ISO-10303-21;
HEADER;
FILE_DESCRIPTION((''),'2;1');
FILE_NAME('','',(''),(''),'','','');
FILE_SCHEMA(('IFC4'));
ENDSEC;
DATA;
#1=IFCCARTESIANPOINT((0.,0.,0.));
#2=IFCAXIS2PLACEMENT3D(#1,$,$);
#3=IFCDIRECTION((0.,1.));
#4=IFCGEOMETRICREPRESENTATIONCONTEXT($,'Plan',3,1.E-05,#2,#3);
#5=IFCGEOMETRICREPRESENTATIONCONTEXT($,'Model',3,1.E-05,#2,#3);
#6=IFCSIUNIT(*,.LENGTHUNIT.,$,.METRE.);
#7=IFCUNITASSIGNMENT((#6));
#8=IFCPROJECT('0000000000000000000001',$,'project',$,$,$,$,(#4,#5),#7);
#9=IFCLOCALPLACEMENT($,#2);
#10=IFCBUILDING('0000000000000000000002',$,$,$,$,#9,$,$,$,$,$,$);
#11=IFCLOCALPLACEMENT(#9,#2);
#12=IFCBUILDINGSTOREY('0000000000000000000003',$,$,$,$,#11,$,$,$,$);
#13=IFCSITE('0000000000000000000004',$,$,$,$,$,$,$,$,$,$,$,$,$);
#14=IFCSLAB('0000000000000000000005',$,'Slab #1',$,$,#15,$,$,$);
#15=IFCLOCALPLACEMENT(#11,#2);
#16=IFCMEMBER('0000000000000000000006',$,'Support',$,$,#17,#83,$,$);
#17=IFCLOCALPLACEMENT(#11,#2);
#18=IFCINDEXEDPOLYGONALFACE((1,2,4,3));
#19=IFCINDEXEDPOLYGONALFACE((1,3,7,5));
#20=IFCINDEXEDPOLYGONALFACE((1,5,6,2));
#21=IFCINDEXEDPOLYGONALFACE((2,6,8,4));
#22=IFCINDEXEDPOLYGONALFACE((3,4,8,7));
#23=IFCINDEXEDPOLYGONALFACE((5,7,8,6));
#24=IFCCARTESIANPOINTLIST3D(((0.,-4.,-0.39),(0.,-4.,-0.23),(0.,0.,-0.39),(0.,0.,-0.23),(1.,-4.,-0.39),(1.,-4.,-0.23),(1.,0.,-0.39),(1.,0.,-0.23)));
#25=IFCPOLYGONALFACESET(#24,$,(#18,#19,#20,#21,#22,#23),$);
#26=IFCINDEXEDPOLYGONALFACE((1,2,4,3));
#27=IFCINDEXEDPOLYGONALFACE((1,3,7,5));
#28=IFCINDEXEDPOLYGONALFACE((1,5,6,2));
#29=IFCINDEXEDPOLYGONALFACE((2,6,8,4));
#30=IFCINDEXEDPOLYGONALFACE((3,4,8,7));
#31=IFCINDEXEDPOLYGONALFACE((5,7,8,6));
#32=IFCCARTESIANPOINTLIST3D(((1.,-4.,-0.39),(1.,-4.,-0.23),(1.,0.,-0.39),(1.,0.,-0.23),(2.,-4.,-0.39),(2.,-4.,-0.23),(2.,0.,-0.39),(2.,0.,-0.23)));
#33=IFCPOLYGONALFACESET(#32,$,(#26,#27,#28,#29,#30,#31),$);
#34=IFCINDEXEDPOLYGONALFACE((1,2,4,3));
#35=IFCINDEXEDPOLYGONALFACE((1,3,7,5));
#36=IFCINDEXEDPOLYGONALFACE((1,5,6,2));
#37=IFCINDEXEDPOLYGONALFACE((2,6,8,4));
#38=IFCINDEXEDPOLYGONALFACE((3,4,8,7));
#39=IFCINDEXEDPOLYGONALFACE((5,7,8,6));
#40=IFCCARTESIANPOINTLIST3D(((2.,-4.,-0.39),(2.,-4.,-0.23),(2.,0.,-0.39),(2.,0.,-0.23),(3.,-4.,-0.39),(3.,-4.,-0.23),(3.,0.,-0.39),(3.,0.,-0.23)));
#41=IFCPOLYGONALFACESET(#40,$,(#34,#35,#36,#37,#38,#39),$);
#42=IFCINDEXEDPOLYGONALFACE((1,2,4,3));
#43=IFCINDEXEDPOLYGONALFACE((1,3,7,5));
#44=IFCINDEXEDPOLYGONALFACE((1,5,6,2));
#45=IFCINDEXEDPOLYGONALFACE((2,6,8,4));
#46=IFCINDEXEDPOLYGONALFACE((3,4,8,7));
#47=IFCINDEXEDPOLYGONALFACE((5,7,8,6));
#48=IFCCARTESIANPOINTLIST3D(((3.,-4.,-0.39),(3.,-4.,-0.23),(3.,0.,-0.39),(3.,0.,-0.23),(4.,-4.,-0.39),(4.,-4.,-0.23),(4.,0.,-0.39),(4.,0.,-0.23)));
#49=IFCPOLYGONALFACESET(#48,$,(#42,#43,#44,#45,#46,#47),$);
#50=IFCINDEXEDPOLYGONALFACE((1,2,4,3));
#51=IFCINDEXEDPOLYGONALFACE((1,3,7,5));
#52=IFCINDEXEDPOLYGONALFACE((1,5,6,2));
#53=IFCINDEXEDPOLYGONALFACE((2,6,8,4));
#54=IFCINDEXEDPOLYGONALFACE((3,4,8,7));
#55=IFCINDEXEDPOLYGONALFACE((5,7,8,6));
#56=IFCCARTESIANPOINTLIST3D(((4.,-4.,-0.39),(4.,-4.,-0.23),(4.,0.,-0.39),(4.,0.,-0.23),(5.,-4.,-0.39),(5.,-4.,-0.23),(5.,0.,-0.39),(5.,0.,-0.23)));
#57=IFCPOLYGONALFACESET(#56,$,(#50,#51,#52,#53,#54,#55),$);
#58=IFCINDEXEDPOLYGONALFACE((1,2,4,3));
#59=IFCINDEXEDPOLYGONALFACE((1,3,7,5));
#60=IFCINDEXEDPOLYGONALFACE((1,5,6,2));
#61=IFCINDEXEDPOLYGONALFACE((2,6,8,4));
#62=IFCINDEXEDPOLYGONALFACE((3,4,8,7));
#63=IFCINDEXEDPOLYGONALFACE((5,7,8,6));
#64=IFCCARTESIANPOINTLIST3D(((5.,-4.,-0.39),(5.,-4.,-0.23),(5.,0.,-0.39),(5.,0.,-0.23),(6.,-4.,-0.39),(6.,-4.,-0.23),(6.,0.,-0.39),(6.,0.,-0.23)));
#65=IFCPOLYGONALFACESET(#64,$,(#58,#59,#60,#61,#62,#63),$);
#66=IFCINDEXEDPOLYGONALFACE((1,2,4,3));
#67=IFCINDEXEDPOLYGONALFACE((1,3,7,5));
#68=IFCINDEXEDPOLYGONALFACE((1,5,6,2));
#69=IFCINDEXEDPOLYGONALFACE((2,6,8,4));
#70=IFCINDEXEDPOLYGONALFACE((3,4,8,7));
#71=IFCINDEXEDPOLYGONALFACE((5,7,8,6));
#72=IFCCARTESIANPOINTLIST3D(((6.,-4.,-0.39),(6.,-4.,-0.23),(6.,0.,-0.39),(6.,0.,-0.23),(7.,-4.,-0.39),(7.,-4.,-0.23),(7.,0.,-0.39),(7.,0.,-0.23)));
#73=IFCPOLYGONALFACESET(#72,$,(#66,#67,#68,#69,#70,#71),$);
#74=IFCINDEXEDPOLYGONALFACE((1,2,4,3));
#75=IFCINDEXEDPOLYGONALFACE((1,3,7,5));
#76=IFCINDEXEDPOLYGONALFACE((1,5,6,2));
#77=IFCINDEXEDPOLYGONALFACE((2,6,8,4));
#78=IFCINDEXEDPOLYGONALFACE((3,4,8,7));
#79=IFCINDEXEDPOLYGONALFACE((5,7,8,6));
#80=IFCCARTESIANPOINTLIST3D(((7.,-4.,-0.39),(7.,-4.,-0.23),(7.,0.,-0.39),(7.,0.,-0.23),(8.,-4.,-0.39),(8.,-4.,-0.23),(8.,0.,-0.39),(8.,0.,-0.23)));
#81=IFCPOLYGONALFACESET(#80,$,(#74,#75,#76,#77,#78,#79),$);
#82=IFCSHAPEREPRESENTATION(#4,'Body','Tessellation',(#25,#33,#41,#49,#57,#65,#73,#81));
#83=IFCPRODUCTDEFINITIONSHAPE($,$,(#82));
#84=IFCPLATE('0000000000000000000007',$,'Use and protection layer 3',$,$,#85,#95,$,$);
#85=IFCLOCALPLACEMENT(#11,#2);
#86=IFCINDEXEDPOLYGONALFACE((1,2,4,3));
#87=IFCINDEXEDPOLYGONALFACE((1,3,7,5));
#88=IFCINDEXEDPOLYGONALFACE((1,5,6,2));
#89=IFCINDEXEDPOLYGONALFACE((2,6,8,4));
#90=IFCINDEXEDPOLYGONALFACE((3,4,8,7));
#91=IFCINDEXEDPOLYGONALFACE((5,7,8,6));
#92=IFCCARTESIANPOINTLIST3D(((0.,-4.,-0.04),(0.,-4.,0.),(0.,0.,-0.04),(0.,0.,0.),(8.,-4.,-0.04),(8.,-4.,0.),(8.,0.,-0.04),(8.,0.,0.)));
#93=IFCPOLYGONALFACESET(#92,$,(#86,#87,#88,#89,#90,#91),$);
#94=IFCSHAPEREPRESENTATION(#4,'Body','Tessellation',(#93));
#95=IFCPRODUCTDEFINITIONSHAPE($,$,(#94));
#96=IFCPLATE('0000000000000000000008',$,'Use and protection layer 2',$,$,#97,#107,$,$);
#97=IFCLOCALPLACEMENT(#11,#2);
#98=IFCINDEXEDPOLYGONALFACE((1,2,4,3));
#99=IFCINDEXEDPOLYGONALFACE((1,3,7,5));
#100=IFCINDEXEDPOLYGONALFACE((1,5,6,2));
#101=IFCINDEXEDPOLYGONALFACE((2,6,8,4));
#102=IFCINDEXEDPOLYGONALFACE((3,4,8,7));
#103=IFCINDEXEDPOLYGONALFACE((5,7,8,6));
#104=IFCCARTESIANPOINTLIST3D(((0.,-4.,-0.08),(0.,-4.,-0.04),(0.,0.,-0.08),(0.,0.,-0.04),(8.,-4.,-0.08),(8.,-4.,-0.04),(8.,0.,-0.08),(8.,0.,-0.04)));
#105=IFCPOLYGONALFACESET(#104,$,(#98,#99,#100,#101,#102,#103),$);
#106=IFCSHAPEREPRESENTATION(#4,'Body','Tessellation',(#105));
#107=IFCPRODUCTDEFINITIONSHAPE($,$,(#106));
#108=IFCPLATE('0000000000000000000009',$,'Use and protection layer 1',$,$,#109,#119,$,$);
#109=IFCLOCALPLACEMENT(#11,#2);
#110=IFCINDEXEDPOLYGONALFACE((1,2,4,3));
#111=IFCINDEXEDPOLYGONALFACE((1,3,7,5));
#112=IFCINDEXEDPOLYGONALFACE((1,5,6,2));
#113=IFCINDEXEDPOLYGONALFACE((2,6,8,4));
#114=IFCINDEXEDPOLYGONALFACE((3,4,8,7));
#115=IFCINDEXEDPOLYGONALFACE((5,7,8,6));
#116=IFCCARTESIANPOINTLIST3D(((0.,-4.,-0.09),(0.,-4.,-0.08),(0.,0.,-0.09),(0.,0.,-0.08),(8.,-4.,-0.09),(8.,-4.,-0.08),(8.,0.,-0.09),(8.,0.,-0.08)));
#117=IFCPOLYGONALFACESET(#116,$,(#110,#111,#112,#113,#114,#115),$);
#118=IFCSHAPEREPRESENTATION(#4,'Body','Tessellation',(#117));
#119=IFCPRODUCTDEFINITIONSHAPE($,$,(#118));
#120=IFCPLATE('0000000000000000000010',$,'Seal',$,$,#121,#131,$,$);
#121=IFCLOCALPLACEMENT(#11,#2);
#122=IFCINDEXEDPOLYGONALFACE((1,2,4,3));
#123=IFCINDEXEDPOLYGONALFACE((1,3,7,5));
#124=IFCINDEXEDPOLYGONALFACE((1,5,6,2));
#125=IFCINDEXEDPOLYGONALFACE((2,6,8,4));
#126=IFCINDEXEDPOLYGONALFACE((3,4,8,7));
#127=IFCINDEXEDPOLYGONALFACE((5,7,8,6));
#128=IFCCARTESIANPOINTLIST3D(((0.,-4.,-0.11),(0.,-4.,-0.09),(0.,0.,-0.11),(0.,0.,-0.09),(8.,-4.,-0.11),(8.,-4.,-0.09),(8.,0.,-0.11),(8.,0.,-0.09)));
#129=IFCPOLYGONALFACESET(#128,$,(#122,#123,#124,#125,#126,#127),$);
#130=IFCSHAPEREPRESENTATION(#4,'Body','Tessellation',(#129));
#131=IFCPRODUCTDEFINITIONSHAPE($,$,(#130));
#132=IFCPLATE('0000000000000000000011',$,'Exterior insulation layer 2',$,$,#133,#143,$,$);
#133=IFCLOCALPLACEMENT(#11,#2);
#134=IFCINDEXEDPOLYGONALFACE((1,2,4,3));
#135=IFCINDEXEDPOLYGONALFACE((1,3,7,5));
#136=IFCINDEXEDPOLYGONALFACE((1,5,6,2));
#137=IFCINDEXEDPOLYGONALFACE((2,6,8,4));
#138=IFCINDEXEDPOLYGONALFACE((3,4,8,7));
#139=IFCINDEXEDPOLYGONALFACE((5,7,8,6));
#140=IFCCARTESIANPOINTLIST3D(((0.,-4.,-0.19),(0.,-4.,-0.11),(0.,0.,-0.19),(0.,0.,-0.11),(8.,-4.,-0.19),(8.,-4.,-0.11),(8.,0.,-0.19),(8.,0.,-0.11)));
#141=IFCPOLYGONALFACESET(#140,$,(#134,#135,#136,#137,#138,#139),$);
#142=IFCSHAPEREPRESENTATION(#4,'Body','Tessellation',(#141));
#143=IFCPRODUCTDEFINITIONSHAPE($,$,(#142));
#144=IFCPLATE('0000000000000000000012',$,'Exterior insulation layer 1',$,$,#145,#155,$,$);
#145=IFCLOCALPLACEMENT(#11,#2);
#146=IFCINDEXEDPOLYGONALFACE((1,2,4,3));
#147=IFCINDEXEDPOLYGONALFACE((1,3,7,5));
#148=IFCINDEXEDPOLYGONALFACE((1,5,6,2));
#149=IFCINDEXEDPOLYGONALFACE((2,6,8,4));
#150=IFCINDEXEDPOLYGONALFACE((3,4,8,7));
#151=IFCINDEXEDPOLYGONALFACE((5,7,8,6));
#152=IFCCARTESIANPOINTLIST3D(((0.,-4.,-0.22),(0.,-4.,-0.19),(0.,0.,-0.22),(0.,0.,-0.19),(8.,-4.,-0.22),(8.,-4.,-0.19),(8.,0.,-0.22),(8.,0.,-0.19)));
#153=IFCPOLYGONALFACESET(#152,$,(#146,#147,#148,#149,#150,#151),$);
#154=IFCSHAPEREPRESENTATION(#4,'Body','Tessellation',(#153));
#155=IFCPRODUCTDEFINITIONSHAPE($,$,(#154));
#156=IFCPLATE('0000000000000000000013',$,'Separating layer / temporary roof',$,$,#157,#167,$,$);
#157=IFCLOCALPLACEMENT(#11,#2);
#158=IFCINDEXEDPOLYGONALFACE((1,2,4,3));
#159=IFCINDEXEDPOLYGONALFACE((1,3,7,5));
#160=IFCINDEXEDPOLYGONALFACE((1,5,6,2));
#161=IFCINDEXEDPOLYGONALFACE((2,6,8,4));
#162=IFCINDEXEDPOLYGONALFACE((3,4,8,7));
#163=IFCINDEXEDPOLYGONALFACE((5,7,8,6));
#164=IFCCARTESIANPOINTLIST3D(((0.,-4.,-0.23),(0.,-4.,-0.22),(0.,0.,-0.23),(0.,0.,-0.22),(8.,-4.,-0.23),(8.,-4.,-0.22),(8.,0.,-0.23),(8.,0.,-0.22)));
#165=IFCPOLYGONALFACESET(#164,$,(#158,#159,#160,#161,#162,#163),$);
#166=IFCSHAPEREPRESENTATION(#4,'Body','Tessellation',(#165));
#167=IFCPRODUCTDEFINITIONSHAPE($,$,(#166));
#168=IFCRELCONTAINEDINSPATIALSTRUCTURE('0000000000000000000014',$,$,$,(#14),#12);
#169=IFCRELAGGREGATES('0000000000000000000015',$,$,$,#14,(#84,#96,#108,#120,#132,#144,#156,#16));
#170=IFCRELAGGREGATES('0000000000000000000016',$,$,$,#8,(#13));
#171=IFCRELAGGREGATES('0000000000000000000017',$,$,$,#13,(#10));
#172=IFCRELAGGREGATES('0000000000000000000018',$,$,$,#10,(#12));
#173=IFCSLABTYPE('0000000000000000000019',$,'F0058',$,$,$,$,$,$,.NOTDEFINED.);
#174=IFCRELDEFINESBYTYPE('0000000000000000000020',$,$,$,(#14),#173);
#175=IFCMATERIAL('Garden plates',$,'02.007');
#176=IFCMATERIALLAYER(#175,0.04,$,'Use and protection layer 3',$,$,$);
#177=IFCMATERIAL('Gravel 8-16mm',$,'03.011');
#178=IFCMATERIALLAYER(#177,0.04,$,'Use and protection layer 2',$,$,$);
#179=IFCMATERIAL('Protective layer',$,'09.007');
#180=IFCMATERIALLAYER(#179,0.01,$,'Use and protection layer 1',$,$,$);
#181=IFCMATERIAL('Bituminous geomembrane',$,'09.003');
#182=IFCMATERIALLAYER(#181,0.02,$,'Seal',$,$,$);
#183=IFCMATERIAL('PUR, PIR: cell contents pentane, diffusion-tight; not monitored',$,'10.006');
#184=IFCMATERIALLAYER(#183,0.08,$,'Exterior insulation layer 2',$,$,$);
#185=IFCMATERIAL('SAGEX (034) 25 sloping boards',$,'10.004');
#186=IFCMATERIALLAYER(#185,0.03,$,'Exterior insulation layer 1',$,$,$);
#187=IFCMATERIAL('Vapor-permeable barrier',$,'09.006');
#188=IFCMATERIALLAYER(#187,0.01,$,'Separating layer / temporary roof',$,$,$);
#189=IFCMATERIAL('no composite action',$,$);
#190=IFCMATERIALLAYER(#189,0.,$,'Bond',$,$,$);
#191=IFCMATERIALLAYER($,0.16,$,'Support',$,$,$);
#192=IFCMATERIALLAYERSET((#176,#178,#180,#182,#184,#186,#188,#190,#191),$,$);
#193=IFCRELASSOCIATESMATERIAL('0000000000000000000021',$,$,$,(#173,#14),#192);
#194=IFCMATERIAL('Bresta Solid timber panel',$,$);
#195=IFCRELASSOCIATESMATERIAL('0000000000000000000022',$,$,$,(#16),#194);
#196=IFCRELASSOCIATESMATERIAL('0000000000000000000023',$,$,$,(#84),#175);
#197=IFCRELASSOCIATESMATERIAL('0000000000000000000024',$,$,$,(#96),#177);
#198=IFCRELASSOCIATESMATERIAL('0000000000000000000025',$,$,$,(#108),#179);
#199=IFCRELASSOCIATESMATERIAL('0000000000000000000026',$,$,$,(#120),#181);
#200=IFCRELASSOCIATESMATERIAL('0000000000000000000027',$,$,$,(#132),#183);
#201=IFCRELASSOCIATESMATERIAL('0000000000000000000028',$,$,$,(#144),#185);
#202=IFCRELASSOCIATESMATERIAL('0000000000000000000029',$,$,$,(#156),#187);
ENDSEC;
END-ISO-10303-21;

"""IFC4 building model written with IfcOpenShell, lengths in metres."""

from ifc_helpers import new_model, si_unit, direction, frame, frame_2d, origin, origin_with_axes, place, context, project, spatial, rectangle, extrude, material, layer, layer_set, type_object, element, aggregate, save


model = new_model("IFC4")

# Units and contexts
plan_context = context("Plan", 3, precision=1e-05, world=origin(), true_north=direction((0.0, 1.0)))
model_context = context("Model", 3, precision=1e-05, world=origin(), true_north=direction((0.0, 1.0)))
ifc_project = project(units=[si_unit("LENGTHUNIT", "METRE")], contexts=[plan_context, model_context])

# Site, building, storey
site = spatial("IfcSite", under=ifc_project)
building_placement = place(None, origin())
building = spatial("IfcBuilding", under=site, at=building_placement)
storey_placement = place(building_placement, origin())
storey = spatial("IfcBuildingStorey", under=building, at=storey_placement)

# Slab, member, plates
ifc_material_1 = material(Name="Garden plates", Category="02.007")
ifc_layer_1 = layer(ifc_material_1, 0.04, Name="Use and protection layer 3")
ifc_material_2 = material(Name="Gravel 8-16mm", Category="03.011")
ifc_layer_2 = layer(ifc_material_2, 0.04, Name="Use and protection layer 2")
ifc_material_3 = material(Name="Protective layer", Category="09.007")
ifc_layer_3 = layer(ifc_material_3, 0.01, Name="Use and protection layer 1")
ifc_material_4 = material(Name="Bituminous geomembrane", Category="09.003")
ifc_layer_4 = layer(ifc_material_4, 0.02, Name="Seal")
ifc_material_5 = material(Name="PUR, PIR: cell contents pentane, diffusion-tight; not monitored", Category="10.006")
ifc_layer_5 = layer(ifc_material_5, 0.08, Name="Exterior insulation layer 2")
ifc_material_6 = material(Name="SAGEX (034) 25 sloping boards", Category="10.004")
ifc_layer_6 = layer(ifc_material_6, 0.03, Name="Exterior insulation layer 1")
ifc_material_7 = material(Name="Vapor-permeable barrier", Category="09.006")
ifc_layer_7 = layer(ifc_material_7, 0.01, Name="Separating layer / temporary roof")
ifc_material_8 = material(Name="no composite action")
ifc_layer_8 = layer(ifc_material_8, 0.0, Name="Bond")
ifc_layer_9 = layer(None, 0.16, Name="Support")
ifc_layer_set = layer_set([ifc_layer_1, ifc_layer_2, ifc_layer_3, ifc_layer_4, ifc_layer_5, ifc_layer_6, ifc_layer_7, ifc_layer_8, ifc_layer_9])
slab_type = type_object("IfcSlabType", Name="F0058", PredefinedType="NOTDEFINED", material=ifc_layer_set)
slab_placement = place(None, frame((0.0, 0.0, 0.0), z_axis=(0.0, 0.0, -1.0), x_axis=(1.0, 0.0, 0.0)))
slab = element("IfcSlab", 1, at=slab_placement, inside=storey, type_object=slab_type, material=ifc_layer_set, Name="Slab #1")
ifc_material_9 = material(Name="Bresta Solid timber panel")
member_placement = place(slab_placement, origin())
member = element("IfcMember", 2, at=member_placement, material=ifc_material_9, Name="Support", context=plan_context, shape_type="SweptSolid", body=[
    extrude(rectangle(XDim=1.0, YDim=0.16, at=frame_2d((0.5, 0.08), x_axis=(1.0, 0.0))), frame((0.0, 4.0, 0.23), z_axis=(0.0, -1.0, 0.0), x_axis=(1.0, 0.0, 0.0)), (0.0, 0.0, 1.0), 4.0),
    extrude(rectangle(XDim=1.0, YDim=0.16, at=frame_2d((0.5, 0.08), x_axis=(1.0, 0.0))), frame((1.0, 4.0, 0.23), z_axis=(0.0, -1.0, 0.0), x_axis=(1.0, 0.0, 0.0)), (0.0, 0.0, 1.0), 4.0),
    extrude(rectangle(XDim=1.0, YDim=0.16, at=frame_2d((0.5, 0.08), x_axis=(1.0, 0.0))), frame((2.0, 4.0, 0.23), z_axis=(0.0, -1.0, 0.0), x_axis=(1.0, 0.0, 0.0)), (0.0, 0.0, 1.0), 4.0),
    extrude(rectangle(XDim=1.0, YDim=0.16, at=frame_2d((0.5, 0.08), x_axis=(1.0, 0.0))), frame((3.0, 4.0, 0.23), z_axis=(0.0, -1.0, 0.0), x_axis=(1.0, 0.0, 0.0)), (0.0, 0.0, 1.0), 4.0),
    extrude(rectangle(XDim=1.0, YDim=0.16, at=frame_2d((0.5, 0.08), x_axis=(1.0, 0.0))), frame((4.0, 4.0, 0.23), z_axis=(0.0, -1.0, 0.0), x_axis=(1.0, 0.0, 0.0)), (0.0, 0.0, 1.0), 4.0),
    extrude(rectangle(XDim=1.0, YDim=0.16, at=frame_2d((0.5, 0.08), x_axis=(1.0, 0.0))), frame((5.0, 4.0, 0.23), z_axis=(0.0, -1.0, 0.0), x_axis=(1.0, 0.0, 0.0)), (0.0, 0.0, 1.0), 4.0),
    extrude(rectangle(XDim=1.0, YDim=0.16, at=frame_2d((0.5, 0.08), x_axis=(1.0, 0.0))), frame((6.0, 4.0, 0.23), z_axis=(0.0, -1.0, 0.0), x_axis=(1.0, 0.0, 0.0)), (0.0, 0.0, 1.0), 4.0),
    extrude(rectangle(XDim=1.0, YDim=0.16, at=frame_2d((0.5, 0.08), x_axis=(1.0, 0.0))), frame((7.0, 4.0, 0.23), z_axis=(0.0, -1.0, 0.0), x_axis=(1.0, 0.0, 0.0)), (0.0, 0.0, 1.0), 4.0),
])
plate_1_placement = place(slab_placement, origin())
plate_1 = element("IfcPlate", 3, at=plate_1_placement, material=ifc_material_1, Name="Use and protection layer 3", context=plan_context, shape_type="SweptSolid", body=[
    extrude(rectangle(XDim=8.0, YDim=4.0, at=frame_2d((4.0, 2.0), x_axis=(1.0, 0.0))), origin_with_axes(), (0.0, 0.0, 1.0), 0.04),
])
plate_2_placement = place(slab_placement, origin())
plate_2 = element("IfcPlate", 4, at=plate_2_placement, material=ifc_material_2, Name="Use and protection layer 2", context=plan_context, shape_type="SweptSolid", body=[
    extrude(rectangle(XDim=8.0, YDim=4.0, at=frame_2d((4.0, 2.0), x_axis=(1.0, 0.0))), frame((0.0, 0.0, 0.04), z_axis=(0.0, 0.0, 1.0), x_axis=(1.0, 0.0, 0.0)), (0.0, 0.0, 1.0), 0.04),
])
plate_3_placement = place(slab_placement, origin())
plate_3 = element("IfcPlate", 5, at=plate_3_placement, material=ifc_material_3, Name="Use and protection layer 1", context=plan_context, shape_type="SweptSolid", body=[
    extrude(rectangle(XDim=8.0, YDim=4.0, at=frame_2d((4.0, 2.0), x_axis=(1.0, 0.0))), frame((0.0, 0.0, 0.08), z_axis=(0.0, 0.0, 1.0), x_axis=(1.0, 0.0, 0.0)), (0.0, 0.0, 1.0), 0.01),
])
plate_4_placement = place(slab_placement, origin())
plate_4 = element("IfcPlate", 6, at=plate_4_placement, material=ifc_material_4, Name="Seal", context=plan_context, shape_type="SweptSolid", body=[
    extrude(rectangle(XDim=8.0, YDim=4.0, at=frame_2d((4.0, 2.0), x_axis=(1.0, 0.0))), frame((0.0, 0.0, 0.09), z_axis=(0.0, 0.0, 1.0), x_axis=(1.0, 0.0, 0.0)), (0.0, 0.0, 1.0), 0.02),
])
plate_5_placement = place(slab_placement, origin())
plate_5 = element("IfcPlate", 7, at=plate_5_placement, material=ifc_material_5, Name="Exterior insulation layer 2", context=plan_context, shape_type="SweptSolid", body=[
    extrude(rectangle(XDim=8.0, YDim=4.0, at=frame_2d((4.0, 2.0), x_axis=(1.0, 0.0))), frame((0.0, 0.0, 0.11), z_axis=(0.0, 0.0, 1.0), x_axis=(1.0, 0.0, 0.0)), (0.0, 0.0, 1.0), 0.08),
])
plate_6_placement = place(slab_placement, origin())
plate_6 = element("IfcPlate", 8, at=plate_6_placement, material=ifc_material_6, Name="Exterior insulation layer 1", context=plan_context, shape_type="SweptSolid", body=[
    extrude(rectangle(XDim=8.0, YDim=4.0, at=frame_2d((4.0, 2.0), x_axis=(1.0, 0.0))), frame((0.0, 0.0, 0.19), z_axis=(0.0, 0.0, 1.0), x_axis=(1.0, 0.0, 0.0)), (0.0, 0.0, 1.0), 0.03),
])
plate_7_placement = place(slab_placement, origin())
plate_7 = element("IfcPlate", 9, at=plate_7_placement, material=ifc_material_7, Name="Separating layer / temporary roof", context=plan_context, shape_type="SweptSolid", body=[
    extrude(rectangle(XDim=8.0, YDim=4.0, at=frame_2d((4.0, 2.0), x_axis=(1.0, 0.0))), frame((0.0, 0.0, 0.22), z_axis=(0.0, 0.0, 1.0), x_axis=(1.0, 0.0, 0.0)), (0.0, 0.0, 1.0), 0.01),
])
aggregate(slab, [plate_1, plate_2, plate_3, plate_4, plate_5, plate_6, plate_7, member])

save(model, "model.ifc")
